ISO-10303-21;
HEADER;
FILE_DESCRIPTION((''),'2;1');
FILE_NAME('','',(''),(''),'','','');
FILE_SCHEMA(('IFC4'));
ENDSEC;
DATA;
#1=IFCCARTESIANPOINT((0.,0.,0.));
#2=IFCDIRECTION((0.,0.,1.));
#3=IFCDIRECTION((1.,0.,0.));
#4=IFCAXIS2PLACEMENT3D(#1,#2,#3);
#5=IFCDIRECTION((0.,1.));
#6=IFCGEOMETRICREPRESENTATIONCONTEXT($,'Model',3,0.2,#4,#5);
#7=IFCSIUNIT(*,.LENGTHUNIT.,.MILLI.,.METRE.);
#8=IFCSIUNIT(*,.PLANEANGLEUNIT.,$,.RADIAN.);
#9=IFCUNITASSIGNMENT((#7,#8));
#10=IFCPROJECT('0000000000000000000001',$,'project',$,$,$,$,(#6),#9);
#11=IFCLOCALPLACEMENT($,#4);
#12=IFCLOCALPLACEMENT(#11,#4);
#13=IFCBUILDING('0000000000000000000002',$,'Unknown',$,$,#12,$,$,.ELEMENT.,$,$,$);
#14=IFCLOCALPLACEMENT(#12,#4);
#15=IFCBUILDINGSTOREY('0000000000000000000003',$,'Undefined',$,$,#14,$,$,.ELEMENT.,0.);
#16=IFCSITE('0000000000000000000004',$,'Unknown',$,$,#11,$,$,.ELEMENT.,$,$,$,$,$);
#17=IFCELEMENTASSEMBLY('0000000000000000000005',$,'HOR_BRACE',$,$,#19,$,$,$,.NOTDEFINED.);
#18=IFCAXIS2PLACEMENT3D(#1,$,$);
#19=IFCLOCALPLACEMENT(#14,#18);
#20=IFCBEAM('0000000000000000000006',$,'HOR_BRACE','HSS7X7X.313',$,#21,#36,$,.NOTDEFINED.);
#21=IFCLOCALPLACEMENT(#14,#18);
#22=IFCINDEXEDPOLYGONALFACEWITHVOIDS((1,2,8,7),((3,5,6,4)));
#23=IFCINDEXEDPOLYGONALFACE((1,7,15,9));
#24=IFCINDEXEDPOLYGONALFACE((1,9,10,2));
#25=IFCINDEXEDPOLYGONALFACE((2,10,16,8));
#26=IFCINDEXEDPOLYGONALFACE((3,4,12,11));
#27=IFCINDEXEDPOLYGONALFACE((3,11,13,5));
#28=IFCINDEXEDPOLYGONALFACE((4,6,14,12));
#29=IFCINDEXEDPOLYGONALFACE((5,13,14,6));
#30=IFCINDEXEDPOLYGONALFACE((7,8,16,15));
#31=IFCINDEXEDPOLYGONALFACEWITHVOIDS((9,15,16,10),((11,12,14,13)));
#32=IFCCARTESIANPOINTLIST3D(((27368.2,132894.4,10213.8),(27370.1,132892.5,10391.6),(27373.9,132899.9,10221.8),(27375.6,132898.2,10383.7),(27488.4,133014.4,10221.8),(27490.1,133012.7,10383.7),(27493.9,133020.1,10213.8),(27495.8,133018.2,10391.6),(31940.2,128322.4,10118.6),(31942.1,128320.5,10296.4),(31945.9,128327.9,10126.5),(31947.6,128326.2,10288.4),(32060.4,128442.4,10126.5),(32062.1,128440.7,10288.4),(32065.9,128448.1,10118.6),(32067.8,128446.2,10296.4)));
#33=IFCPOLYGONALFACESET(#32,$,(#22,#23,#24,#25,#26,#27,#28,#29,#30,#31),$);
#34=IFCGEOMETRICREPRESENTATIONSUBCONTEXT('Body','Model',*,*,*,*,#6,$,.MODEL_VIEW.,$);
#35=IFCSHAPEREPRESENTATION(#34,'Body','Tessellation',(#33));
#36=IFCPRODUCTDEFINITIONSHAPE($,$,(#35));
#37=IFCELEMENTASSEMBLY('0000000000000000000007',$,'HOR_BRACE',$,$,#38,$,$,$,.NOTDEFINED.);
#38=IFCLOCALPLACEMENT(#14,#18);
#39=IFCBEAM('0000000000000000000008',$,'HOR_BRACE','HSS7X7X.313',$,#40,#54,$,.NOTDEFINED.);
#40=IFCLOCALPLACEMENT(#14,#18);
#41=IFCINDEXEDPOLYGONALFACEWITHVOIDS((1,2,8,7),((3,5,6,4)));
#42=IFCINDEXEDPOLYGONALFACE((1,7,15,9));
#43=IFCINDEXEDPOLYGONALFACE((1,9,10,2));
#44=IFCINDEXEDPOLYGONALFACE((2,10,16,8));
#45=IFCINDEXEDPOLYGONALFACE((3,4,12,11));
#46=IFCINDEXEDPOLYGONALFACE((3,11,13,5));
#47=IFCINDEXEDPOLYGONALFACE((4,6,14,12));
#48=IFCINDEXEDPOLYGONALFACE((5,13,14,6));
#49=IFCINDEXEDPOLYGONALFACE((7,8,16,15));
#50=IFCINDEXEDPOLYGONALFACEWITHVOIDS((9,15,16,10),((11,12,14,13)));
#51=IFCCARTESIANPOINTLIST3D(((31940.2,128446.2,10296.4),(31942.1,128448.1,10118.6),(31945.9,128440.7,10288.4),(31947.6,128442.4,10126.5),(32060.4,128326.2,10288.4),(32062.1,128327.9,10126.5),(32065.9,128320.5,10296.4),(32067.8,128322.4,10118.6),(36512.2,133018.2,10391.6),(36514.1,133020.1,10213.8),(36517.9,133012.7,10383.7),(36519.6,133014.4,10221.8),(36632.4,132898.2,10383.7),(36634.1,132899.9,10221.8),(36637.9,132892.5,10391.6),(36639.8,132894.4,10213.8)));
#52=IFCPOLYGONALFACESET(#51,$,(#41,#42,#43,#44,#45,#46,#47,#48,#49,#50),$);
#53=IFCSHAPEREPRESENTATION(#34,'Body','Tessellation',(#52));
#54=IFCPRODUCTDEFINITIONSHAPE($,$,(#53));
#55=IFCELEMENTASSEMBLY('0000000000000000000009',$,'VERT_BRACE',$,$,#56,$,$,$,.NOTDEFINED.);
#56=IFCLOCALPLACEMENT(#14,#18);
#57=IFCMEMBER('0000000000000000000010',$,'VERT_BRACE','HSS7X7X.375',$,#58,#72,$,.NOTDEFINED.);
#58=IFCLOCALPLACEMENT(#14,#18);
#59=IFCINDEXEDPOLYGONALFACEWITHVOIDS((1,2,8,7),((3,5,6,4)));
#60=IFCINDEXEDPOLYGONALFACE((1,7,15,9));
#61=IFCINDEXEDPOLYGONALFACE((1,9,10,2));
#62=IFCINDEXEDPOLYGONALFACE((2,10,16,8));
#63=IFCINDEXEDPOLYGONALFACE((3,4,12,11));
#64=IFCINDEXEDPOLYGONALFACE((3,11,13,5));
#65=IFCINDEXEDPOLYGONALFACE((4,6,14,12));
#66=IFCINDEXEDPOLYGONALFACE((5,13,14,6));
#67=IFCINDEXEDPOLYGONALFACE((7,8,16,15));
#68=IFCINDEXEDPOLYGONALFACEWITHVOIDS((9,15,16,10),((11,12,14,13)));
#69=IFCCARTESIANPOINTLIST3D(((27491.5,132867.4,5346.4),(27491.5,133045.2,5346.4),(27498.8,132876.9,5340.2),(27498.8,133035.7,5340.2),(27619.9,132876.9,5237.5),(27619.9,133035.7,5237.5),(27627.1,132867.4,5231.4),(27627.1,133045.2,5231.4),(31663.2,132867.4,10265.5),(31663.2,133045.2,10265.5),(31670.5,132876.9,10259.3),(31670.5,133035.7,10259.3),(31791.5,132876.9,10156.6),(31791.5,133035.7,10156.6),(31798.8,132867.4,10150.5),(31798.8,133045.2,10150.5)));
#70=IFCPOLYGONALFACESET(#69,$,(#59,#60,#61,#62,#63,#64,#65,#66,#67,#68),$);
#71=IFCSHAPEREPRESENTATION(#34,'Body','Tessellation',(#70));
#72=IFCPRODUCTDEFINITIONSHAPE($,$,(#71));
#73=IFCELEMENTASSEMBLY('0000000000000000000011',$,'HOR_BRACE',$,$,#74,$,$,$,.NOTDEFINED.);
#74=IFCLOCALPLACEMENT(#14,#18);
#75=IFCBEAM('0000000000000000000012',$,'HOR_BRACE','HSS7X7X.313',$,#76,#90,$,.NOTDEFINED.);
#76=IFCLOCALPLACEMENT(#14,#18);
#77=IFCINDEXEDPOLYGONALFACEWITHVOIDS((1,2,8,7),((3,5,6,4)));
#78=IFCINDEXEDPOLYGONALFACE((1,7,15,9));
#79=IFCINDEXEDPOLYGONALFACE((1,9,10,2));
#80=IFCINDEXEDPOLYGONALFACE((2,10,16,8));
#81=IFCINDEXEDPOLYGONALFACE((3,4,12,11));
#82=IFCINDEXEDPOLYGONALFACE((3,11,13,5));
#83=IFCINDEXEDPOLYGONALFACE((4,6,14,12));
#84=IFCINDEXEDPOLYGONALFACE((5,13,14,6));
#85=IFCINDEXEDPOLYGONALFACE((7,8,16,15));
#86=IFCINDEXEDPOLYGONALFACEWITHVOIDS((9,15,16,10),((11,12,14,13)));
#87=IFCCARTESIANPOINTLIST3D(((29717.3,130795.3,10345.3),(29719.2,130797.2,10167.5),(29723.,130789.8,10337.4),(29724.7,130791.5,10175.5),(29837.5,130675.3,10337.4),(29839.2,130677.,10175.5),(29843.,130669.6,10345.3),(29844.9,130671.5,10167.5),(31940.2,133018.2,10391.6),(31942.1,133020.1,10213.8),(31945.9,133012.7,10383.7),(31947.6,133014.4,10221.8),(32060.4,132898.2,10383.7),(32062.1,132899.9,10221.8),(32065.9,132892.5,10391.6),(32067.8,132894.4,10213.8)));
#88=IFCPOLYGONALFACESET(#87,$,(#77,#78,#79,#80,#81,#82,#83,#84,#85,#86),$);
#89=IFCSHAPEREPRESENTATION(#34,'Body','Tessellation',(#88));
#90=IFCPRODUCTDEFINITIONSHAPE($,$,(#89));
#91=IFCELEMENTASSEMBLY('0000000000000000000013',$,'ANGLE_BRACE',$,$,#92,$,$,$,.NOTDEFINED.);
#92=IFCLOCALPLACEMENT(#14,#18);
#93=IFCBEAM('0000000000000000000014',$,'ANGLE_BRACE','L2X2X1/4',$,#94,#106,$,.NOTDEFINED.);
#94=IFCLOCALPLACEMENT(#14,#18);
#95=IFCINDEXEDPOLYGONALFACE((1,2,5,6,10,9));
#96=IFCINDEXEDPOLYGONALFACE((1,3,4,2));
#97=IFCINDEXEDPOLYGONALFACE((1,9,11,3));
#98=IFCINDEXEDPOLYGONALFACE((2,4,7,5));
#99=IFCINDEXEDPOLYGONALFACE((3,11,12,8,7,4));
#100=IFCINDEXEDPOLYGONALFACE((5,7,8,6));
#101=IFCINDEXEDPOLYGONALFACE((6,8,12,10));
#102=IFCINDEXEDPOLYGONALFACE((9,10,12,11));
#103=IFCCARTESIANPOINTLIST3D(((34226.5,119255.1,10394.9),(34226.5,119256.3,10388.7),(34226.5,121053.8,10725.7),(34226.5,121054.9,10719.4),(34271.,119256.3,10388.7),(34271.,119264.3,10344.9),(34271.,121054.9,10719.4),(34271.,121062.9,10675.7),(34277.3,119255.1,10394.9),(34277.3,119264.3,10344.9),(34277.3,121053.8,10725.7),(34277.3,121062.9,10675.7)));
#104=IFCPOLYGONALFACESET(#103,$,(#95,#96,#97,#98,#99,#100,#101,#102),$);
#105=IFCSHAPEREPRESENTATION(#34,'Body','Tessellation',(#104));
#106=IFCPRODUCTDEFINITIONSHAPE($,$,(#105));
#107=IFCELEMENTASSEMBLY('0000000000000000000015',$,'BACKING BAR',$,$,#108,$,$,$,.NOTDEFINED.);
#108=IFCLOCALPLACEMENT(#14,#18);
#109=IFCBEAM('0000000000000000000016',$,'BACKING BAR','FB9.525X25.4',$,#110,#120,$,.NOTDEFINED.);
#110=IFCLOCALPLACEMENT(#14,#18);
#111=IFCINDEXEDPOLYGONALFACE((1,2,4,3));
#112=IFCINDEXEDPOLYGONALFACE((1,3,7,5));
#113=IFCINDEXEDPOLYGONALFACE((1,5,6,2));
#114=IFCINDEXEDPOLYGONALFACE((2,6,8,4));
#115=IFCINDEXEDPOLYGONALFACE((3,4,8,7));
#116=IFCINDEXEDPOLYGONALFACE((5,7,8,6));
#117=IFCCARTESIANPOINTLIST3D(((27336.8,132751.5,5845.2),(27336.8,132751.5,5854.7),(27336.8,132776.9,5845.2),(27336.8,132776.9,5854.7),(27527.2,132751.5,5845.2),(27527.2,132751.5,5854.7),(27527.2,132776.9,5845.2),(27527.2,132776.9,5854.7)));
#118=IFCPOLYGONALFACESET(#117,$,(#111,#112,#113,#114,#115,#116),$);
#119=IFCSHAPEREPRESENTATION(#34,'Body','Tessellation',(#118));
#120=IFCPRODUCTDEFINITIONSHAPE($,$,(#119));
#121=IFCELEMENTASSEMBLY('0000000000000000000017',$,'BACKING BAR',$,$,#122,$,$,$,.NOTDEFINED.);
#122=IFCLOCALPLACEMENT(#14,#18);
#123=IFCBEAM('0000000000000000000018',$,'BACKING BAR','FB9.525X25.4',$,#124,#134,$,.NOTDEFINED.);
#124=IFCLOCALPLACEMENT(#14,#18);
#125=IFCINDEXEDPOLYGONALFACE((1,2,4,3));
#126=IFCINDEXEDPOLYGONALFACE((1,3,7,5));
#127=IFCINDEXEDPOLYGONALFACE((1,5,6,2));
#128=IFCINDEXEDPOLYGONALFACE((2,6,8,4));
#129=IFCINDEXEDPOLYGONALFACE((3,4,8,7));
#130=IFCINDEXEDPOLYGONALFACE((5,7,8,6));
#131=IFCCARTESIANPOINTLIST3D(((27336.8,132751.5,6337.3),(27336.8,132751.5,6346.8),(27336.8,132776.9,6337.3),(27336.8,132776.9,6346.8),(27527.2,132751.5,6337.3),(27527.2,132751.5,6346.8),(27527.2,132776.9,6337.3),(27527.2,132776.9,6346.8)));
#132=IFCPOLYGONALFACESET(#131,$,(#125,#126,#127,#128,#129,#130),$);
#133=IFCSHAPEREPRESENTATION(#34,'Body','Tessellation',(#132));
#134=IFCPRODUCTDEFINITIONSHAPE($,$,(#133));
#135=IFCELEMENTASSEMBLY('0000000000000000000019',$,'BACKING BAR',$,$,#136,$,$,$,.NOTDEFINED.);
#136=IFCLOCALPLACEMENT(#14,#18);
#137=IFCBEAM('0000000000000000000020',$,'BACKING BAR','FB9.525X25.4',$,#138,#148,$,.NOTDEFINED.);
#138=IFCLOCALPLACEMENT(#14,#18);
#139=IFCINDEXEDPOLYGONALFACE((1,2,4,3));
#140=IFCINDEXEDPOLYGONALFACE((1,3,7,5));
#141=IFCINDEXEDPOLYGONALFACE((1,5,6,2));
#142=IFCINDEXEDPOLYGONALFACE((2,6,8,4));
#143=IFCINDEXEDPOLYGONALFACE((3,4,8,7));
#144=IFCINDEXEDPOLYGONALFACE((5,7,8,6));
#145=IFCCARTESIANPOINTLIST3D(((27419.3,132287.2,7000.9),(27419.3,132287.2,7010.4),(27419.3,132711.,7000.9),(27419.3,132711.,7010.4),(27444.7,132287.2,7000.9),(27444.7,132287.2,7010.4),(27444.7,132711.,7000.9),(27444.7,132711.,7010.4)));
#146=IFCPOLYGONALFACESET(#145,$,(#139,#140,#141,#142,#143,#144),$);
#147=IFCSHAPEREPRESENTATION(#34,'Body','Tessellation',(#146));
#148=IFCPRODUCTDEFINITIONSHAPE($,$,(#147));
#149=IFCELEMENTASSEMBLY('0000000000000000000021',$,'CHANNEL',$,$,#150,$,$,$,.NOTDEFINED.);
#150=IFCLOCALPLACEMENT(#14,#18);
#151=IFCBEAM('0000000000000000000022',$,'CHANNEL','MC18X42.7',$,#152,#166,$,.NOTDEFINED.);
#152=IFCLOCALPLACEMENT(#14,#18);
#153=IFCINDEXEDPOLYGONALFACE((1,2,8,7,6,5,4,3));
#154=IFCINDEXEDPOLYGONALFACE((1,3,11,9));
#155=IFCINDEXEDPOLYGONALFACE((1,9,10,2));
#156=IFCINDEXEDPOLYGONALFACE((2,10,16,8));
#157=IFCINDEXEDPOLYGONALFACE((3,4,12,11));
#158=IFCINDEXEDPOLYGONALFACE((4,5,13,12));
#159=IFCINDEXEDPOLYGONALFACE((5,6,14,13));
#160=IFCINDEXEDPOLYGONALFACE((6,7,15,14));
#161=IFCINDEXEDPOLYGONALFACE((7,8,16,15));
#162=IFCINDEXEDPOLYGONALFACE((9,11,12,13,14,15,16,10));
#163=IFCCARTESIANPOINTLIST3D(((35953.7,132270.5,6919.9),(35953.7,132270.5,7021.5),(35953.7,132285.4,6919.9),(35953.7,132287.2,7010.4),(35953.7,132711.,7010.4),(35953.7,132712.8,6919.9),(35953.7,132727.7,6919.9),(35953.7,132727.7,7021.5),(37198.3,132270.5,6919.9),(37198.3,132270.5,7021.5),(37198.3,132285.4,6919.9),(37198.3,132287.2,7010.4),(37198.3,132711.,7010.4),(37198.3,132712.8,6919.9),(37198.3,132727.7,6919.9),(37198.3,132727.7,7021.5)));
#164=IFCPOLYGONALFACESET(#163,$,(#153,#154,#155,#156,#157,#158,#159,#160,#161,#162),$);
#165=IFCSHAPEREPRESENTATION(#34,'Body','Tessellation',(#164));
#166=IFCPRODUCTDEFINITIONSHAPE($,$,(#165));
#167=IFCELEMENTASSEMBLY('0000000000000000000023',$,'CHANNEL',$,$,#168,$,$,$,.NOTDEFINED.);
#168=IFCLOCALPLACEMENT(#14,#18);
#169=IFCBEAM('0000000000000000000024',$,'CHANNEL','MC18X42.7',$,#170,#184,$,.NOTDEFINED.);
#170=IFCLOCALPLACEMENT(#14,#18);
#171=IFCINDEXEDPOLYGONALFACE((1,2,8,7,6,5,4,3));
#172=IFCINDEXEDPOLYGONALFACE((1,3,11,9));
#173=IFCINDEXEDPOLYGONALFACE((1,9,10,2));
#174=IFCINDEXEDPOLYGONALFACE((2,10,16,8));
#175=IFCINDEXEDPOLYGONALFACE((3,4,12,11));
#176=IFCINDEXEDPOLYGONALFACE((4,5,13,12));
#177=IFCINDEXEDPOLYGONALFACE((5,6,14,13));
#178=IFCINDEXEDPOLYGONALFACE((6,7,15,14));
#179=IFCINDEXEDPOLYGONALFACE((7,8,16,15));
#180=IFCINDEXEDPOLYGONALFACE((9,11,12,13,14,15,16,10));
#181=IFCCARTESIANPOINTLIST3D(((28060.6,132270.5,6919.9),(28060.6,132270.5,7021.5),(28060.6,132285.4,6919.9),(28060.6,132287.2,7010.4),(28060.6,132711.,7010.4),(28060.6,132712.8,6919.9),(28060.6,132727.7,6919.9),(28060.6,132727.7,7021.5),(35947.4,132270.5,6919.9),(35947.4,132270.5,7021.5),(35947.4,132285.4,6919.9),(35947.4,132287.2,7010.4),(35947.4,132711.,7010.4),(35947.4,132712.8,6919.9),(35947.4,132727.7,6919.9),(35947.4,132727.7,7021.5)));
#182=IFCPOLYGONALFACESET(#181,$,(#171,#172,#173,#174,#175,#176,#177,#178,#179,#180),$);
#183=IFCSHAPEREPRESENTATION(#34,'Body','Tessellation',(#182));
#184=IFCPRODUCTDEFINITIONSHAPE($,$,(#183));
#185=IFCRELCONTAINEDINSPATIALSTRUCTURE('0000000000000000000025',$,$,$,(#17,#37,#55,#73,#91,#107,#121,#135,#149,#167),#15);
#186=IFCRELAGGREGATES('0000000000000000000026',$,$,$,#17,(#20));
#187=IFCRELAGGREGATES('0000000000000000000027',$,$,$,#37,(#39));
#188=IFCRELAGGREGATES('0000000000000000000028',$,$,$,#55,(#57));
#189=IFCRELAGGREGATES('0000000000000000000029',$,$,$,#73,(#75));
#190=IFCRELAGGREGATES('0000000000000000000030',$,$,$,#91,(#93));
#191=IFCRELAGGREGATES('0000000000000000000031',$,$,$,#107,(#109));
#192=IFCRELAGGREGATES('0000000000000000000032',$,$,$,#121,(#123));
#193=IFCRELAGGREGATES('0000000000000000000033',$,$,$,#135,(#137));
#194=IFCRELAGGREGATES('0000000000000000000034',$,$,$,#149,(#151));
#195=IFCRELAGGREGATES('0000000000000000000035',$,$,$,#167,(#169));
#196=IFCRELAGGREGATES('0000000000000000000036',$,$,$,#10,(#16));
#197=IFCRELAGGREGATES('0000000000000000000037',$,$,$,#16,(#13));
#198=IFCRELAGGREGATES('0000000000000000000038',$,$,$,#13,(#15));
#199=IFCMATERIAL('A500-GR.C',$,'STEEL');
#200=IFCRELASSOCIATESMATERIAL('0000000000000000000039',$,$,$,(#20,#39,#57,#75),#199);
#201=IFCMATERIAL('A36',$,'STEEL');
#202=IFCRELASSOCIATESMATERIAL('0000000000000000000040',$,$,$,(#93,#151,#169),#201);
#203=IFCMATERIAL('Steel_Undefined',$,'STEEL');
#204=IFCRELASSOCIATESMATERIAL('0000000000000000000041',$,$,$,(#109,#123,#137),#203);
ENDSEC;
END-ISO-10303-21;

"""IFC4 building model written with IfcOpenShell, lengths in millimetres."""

from ifc_helpers import new_model, si_unit, direction, frame, origin_with_axes, place, context, subcontext, project, spatial, line, indexed_curve, outline, extrude, material, element, aggregate, save


model = new_model("IFC4")

# Units and contexts
model_context = context("Model", 3, precision=0.2, world=origin_with_axes(), true_north=direction((0.0, 1.0)))
body_context = subcontext(model_context, "Body", "Model", "MODEL_VIEW")
ifc_project = project(units=[si_unit("LENGTHUNIT", "METRE", prefix="MILLI"), si_unit("PLANEANGLEUNIT", "RADIAN")], contexts=[model_context])

# Site, building, storey
site_placement = place(None, origin_with_axes())
site = spatial("IfcSite", under=ifc_project, at=site_placement, Name="Unknown", CompositionType="ELEMENT")
building_placement = place(site_placement, origin_with_axes())
building = spatial("IfcBuilding", under=site, at=building_placement, Name="Unknown", CompositionType="ELEMENT")
storey_placement = place(building_placement, origin_with_axes())
storey = spatial("IfcBuildingStorey", under=building, at=storey_placement, Name="Undefined", CompositionType="ELEMENT", Elevation=0.0)

# Shared definitions
ifc_material_1 = material(Name="A500-GR.C", Category="STEEL")

# Element assemblies, beams
assembly_1_placement = place(storey_placement, frame((32004.0, 128384.3, 10207.5), z_axis=(0.707107, 0.707107, 0.0), x_axis=(-0.70703, 0.70703, 0.01473)))
assembly_1 = element("IfcElementAssembly", 1, at=assembly_1_placement, inside=storey, Name="HOR_BRACE", PredefinedType="NOTDEFINED")
beam_1_placement = place(assembly_1_placement, origin_with_axes())
beam_1 = element("IfcBeam", 2, at=beam_1_placement, material=ifc_material_1, Name="HOR_BRACE", Description="HSS7X7X.313", PredefinedType="NOTDEFINED", context=body_context, shape_type="SolidModel", body=[
    extrude(outline(indexed_curve([(-88.9, -88.9), (88.9, -88.9), (88.9, 88.9), (-88.9, 88.9)], segments=[line(1, 2, 3, 4, 1)]), holes=[indexed_curve([(-81.0, -81.0), (-81.0, 81.0), (81.0, 81.0), (81.0, -81.0)], segments=[line(1, 2, 3, 4, 1)])]), frame((0.0, 0.0, 0.0), z_axis=(-1.0, 0.0, 0.0), x_axis=(0.0, 0.0, 1.0)), (0.0, 0.0, -1.0), 6466.5),
])
aggregate(assembly_1, [beam_1])
assembly_2_placement = place(storey_placement, frame((32004.0, 128384.3, 10207.5), z_axis=(0.707107, -0.707107, 0.0), x_axis=(0.70703, 0.70703, 0.01473)))
assembly_2 = element("IfcElementAssembly", 3, at=assembly_2_placement, inside=storey, Name="HOR_BRACE", PredefinedType="NOTDEFINED")
beam_2_placement = place(assembly_2_placement, origin_with_axes())
beam_2 = element("IfcBeam", 4, at=beam_2_placement, material=ifc_material_1, Name="HOR_BRACE", Description="HSS7X7X.313", PredefinedType="NOTDEFINED", context=body_context, shape_type="SolidModel", body=[
    extrude(outline(indexed_curve([(-88.9, -88.9), (88.9, -88.9), (88.9, 88.9), (-88.9, 88.9)], segments=[line(1, 2, 3, 4, 1)]), holes=[indexed_curve([(-81.0, -81.0), (-81.0, 81.0), (81.0, 81.0), (81.0, -81.0)], segments=[line(1, 2, 3, 4, 1)])]), frame((0.0, 0.0, 0.0), z_axis=(-1.0, 0.0, 0.0), x_axis=(0.0, 0.0, 1.0)), (0.0, 0.0, -1.0), 6466.5),
])
aggregate(assembly_2, [beam_2])

# Element assembly, member
assembly_3_placement = place(storey_placement, frame((27559.3, 132956.3, 5288.9), z_axis=(0.0, -1.0, 0.0), x_axis=(0.646788, 0.0, 0.76267)))
assembly_3 = element("IfcElementAssembly", 5, at=assembly_3_placement, inside=storey, Name="VERT_BRACE", PredefinedType="NOTDEFINED")
member_1_placement = place(assembly_3_placement, origin_with_axes())
member_1 = element("IfcMember", 6, at=member_1_placement, material=ifc_material_1, Name="VERT_BRACE", Description="HSS7X7X.375", PredefinedType="NOTDEFINED", context=body_context, shape_type="SolidModel", body=[
    extrude(outline(indexed_curve([(-88.9, -88.9), (88.9, -88.9), (88.9, 88.9), (-88.9, 88.9)], segments=[line(1, 2, 3, 4, 1)]), holes=[indexed_curve([(-79.4, -79.4), (-79.4, 79.4), (79.4, 79.4), (79.4, -79.4)], segments=[line(1, 2, 3, 4, 1)])]), frame((0.0, 0.0, 0.0), z_axis=(-1.0, 0.0, 0.0), x_axis=(0.0, 0.0, 1.0)), (0.0, 0.0, -1.0), 6449.9),
])
aggregate(assembly_3, [member_1])

# Element assemblies, beams
assembly_4_placement = place(storey_placement, frame((29781.1, 130733.4, 10256.4), z_axis=(0.707107, -0.707107, 0.0), x_axis=(0.70703, 0.70703, 0.01473)))
assembly_4 = element("IfcElementAssembly", 7, at=assembly_4_placement, inside=storey, Name="HOR_BRACE", PredefinedType="NOTDEFINED")
beam_3_placement = place(assembly_4_placement, origin_with_axes())
beam_3 = element("IfcBeam", 8, at=beam_3_placement, material=ifc_material_1, Name="HOR_BRACE", Description="HSS7X7X.313", PredefinedType="NOTDEFINED", context=body_context, shape_type="SolidModel", body=[
    extrude(outline(indexed_curve([(-88.9, -88.9), (88.9, -88.9), (88.9, 88.9), (-88.9, 88.9)], segments=[line(1, 2, 3, 4, 1)]), holes=[indexed_curve([(-81.0, -81.0), (-81.0, 81.0), (81.0, 81.0), (81.0, -81.0)], segments=[line(1, 2, 3, 4, 1)])]), frame((0.0, 0.0, 0.0), z_axis=(-1.0, 0.0, 0.0), x_axis=(0.0, 0.0, 1.0)), (0.0, 0.0, -1.0), 3144.0),
])
aggregate(assembly_4, [beam_3])
assembly_5_placement = place(storey_placement, frame((34251.9, 121058.4, 10700.7), z_axis=(0.0, 0.180854, -0.98351), x_axis=(0.0, -0.98351, -0.180854)))
assembly_5 = element("IfcElementAssembly", 9, at=assembly_5_placement, inside=storey, Name="ANGLE_BRACE", PredefinedType="NOTDEFINED")
ifc_material_2 = material(Name="A36", Category="STEEL")
beam_4_placement = place(assembly_5_placement, origin_with_axes())
beam_4 = element("IfcBeam", 10, at=beam_4_placement, material=ifc_material_2, Name="ANGLE_BRACE", Description="L2X2X1/4", PredefinedType="NOTDEFINED", context=body_context, shape_type="SolidModel", body=[
    extrude(outline(indexed_curve([(-25.4, -25.4), (25.4, -25.4), (25.4, -19.1), (-19.1, -19.1), (-19.1, 25.4), (-25.4, 25.4)], segments=[line(1, 2, 3, 4, 5, 6, 1)])), frame((0.0, 0.0, 0.0), z_axis=(-1.0, 0.0, 0.0), x_axis=(0.0, 0.0, 1.0)), (0.0, 0.0, -1.0), 1828.8),
])
aggregate(assembly_5, [beam_4])
assembly_6_placement = place(storey_placement, frame((27527.2, 132764.2, 5849.9), z_axis=(0.0, 0.0, 1.0), x_axis=(-1.0, 0.0, 0.0)))
assembly_6 = element("IfcElementAssembly", 11, at=assembly_6_placement, inside=storey, Name="BACKING BAR", PredefinedType="NOTDEFINED")
ifc_material_3 = material(Name="Steel_Undefined", Category="STEEL")
beam_5_placement = place(assembly_6_placement, origin_with_axes())
beam_5 = element("IfcBeam", 12, at=beam_5_placement, material=ifc_material_3, Name="BACKING BAR", Description="FB9.525X25.4", PredefinedType="NOTDEFINED", context=body_context, shape_type="SolidModel", body=[
    extrude(outline(indexed_curve([(-4.8, -12.7), (4.8, -12.7), (4.8, 12.7), (-4.8, 12.7)], segments=[line(1, 2, 3, 4, 1)])), frame((0.0, 0.0, 0.0), z_axis=(-1.0, 0.0, 0.0), x_axis=(0.0, 0.0, 1.0)), (0.0, 0.0, -1.0), 190.5),
])
aggregate(assembly_6, [beam_5])
assembly_7_placement = place(storey_placement, frame((27527.2, 132764.2, 6342.1), z_axis=(0.0, 0.0, 1.0), x_axis=(-1.0, 0.0, 0.0)))
assembly_7 = element("IfcElementAssembly", 13, at=assembly_7_placement, inside=storey, Name="BACKING BAR", PredefinedType="NOTDEFINED")
beam_6_placement = place(assembly_7_placement, origin_with_axes())
beam_6 = element("IfcBeam", 14, at=beam_6_placement, material=ifc_material_3, Name="BACKING BAR", Description="FB9.525X25.4", PredefinedType="NOTDEFINED", context=body_context, shape_type="SolidModel", body=[
    extrude(outline(indexed_curve([(-4.8, -12.7), (4.8, -12.7), (4.8, 12.7), (-4.8, 12.7)], segments=[line(1, 2, 3, 4, 1)])), frame((0.0, 0.0, 0.0), z_axis=(-1.0, 0.0, 0.0), x_axis=(0.0, 0.0, 1.0)), (0.0, 0.0, -1.0), 190.5),
])
aggregate(assembly_7, [beam_6])
assembly_8_placement = place(storey_placement, frame((27432.0, 132711.0, 7005.6), z_axis=(0.0, 0.0, 1.0), x_axis=(0.0, -1.0, 0.0)))
assembly_8 = element("IfcElementAssembly", 15, at=assembly_8_placement, inside=storey, Name="BACKING BAR", PredefinedType="NOTDEFINED")
beam_7_placement = place(assembly_8_placement, origin_with_axes())
beam_7 = element("IfcBeam", 16, at=beam_7_placement, material=ifc_material_3, Name="BACKING BAR", Description="FB9.525X25.4", PredefinedType="NOTDEFINED", context=body_context, shape_type="SolidModel", body=[
    extrude(outline(indexed_curve([(-4.8, -12.7), (4.8, -12.7), (4.8, 12.7), (-4.8, 12.7)], segments=[line(1, 2, 3, 4, 1)])), frame((0.0, 0.0, 0.0), z_axis=(-1.0, 0.0, 0.0), x_axis=(0.0, 0.0, 1.0)), (0.0, 0.0, -1.0), 423.9),
])
aggregate(assembly_8, [beam_7])
assembly_9_placement = place(storey_placement, frame((35953.7, 132499.1, 6970.7), z_axis=(0.0, 0.0, -1.0), x_axis=(1.0, 0.0, 0.0)))
assembly_9 = element("IfcElementAssembly", 17, at=assembly_9_placement, inside=storey, Name="CHANNEL", PredefinedType="NOTDEFINED")
beam_8_placement = place(assembly_9_placement, origin_with_axes())
beam_8 = element("IfcBeam", 18, at=beam_8_placement, material=ifc_material_2, Name="CHANNEL", Description="MC18X42.7", PredefinedType="NOTDEFINED", context=body_context, shape_type="SolidModel", body=[
    extrude(outline(indexed_curve([(-50.8, -228.6), (50.8, -228.6), (50.8, -213.7), (-39.7, -211.9), (-39.7, 211.9), (50.8, 213.7), (50.8, 228.6), (-50.8, 228.6)], segments=[line(1, 2, 3, 4, 5, 6, 7, 8, 1)])), frame((0.0, 0.0, 0.0), z_axis=(-1.0, 0.0, 0.0), x_axis=(0.0, 0.0, 1.0)), (0.0, 0.0, -1.0), 1244.6),
])
aggregate(assembly_9, [beam_8])
assembly_10_placement = place(storey_placement, frame((35947.3, 132499.1, 6970.7), z_axis=(0.0, 0.0, -1.0), x_axis=(-1.0, 0.0, 0.0)))
assembly_10 = element("IfcElementAssembly", 19, at=assembly_10_placement, inside=storey, Name="CHANNEL", PredefinedType="NOTDEFINED")
beam_9_placement = place(assembly_10_placement, origin_with_axes())
beam_9 = element("IfcBeam", 20, at=beam_9_placement, material=ifc_material_2, Name="CHANNEL", Description="MC18X42.7", PredefinedType="NOTDEFINED", context=body_context, shape_type="SolidModel", body=[
    extrude(outline(indexed_curve([(-50.8, -228.6), (50.8, -228.6), (50.8, -213.7), (-39.7, -211.9), (-39.7, 211.9), (50.8, 213.7), (50.8, 228.6), (-50.8, 228.6)], segments=[line(1, 2, 3, 4, 5, 6, 7, 8, 1)])), frame((0.0, 0.0, 0.0), z_axis=(-1.0, 0.0, 0.0), x_axis=(0.0, 0.0, 1.0)), (0.0, 0.0, -1.0), 7886.7),
])
aggregate(assembly_10, [beam_9])

save(model, "model.ifc")
